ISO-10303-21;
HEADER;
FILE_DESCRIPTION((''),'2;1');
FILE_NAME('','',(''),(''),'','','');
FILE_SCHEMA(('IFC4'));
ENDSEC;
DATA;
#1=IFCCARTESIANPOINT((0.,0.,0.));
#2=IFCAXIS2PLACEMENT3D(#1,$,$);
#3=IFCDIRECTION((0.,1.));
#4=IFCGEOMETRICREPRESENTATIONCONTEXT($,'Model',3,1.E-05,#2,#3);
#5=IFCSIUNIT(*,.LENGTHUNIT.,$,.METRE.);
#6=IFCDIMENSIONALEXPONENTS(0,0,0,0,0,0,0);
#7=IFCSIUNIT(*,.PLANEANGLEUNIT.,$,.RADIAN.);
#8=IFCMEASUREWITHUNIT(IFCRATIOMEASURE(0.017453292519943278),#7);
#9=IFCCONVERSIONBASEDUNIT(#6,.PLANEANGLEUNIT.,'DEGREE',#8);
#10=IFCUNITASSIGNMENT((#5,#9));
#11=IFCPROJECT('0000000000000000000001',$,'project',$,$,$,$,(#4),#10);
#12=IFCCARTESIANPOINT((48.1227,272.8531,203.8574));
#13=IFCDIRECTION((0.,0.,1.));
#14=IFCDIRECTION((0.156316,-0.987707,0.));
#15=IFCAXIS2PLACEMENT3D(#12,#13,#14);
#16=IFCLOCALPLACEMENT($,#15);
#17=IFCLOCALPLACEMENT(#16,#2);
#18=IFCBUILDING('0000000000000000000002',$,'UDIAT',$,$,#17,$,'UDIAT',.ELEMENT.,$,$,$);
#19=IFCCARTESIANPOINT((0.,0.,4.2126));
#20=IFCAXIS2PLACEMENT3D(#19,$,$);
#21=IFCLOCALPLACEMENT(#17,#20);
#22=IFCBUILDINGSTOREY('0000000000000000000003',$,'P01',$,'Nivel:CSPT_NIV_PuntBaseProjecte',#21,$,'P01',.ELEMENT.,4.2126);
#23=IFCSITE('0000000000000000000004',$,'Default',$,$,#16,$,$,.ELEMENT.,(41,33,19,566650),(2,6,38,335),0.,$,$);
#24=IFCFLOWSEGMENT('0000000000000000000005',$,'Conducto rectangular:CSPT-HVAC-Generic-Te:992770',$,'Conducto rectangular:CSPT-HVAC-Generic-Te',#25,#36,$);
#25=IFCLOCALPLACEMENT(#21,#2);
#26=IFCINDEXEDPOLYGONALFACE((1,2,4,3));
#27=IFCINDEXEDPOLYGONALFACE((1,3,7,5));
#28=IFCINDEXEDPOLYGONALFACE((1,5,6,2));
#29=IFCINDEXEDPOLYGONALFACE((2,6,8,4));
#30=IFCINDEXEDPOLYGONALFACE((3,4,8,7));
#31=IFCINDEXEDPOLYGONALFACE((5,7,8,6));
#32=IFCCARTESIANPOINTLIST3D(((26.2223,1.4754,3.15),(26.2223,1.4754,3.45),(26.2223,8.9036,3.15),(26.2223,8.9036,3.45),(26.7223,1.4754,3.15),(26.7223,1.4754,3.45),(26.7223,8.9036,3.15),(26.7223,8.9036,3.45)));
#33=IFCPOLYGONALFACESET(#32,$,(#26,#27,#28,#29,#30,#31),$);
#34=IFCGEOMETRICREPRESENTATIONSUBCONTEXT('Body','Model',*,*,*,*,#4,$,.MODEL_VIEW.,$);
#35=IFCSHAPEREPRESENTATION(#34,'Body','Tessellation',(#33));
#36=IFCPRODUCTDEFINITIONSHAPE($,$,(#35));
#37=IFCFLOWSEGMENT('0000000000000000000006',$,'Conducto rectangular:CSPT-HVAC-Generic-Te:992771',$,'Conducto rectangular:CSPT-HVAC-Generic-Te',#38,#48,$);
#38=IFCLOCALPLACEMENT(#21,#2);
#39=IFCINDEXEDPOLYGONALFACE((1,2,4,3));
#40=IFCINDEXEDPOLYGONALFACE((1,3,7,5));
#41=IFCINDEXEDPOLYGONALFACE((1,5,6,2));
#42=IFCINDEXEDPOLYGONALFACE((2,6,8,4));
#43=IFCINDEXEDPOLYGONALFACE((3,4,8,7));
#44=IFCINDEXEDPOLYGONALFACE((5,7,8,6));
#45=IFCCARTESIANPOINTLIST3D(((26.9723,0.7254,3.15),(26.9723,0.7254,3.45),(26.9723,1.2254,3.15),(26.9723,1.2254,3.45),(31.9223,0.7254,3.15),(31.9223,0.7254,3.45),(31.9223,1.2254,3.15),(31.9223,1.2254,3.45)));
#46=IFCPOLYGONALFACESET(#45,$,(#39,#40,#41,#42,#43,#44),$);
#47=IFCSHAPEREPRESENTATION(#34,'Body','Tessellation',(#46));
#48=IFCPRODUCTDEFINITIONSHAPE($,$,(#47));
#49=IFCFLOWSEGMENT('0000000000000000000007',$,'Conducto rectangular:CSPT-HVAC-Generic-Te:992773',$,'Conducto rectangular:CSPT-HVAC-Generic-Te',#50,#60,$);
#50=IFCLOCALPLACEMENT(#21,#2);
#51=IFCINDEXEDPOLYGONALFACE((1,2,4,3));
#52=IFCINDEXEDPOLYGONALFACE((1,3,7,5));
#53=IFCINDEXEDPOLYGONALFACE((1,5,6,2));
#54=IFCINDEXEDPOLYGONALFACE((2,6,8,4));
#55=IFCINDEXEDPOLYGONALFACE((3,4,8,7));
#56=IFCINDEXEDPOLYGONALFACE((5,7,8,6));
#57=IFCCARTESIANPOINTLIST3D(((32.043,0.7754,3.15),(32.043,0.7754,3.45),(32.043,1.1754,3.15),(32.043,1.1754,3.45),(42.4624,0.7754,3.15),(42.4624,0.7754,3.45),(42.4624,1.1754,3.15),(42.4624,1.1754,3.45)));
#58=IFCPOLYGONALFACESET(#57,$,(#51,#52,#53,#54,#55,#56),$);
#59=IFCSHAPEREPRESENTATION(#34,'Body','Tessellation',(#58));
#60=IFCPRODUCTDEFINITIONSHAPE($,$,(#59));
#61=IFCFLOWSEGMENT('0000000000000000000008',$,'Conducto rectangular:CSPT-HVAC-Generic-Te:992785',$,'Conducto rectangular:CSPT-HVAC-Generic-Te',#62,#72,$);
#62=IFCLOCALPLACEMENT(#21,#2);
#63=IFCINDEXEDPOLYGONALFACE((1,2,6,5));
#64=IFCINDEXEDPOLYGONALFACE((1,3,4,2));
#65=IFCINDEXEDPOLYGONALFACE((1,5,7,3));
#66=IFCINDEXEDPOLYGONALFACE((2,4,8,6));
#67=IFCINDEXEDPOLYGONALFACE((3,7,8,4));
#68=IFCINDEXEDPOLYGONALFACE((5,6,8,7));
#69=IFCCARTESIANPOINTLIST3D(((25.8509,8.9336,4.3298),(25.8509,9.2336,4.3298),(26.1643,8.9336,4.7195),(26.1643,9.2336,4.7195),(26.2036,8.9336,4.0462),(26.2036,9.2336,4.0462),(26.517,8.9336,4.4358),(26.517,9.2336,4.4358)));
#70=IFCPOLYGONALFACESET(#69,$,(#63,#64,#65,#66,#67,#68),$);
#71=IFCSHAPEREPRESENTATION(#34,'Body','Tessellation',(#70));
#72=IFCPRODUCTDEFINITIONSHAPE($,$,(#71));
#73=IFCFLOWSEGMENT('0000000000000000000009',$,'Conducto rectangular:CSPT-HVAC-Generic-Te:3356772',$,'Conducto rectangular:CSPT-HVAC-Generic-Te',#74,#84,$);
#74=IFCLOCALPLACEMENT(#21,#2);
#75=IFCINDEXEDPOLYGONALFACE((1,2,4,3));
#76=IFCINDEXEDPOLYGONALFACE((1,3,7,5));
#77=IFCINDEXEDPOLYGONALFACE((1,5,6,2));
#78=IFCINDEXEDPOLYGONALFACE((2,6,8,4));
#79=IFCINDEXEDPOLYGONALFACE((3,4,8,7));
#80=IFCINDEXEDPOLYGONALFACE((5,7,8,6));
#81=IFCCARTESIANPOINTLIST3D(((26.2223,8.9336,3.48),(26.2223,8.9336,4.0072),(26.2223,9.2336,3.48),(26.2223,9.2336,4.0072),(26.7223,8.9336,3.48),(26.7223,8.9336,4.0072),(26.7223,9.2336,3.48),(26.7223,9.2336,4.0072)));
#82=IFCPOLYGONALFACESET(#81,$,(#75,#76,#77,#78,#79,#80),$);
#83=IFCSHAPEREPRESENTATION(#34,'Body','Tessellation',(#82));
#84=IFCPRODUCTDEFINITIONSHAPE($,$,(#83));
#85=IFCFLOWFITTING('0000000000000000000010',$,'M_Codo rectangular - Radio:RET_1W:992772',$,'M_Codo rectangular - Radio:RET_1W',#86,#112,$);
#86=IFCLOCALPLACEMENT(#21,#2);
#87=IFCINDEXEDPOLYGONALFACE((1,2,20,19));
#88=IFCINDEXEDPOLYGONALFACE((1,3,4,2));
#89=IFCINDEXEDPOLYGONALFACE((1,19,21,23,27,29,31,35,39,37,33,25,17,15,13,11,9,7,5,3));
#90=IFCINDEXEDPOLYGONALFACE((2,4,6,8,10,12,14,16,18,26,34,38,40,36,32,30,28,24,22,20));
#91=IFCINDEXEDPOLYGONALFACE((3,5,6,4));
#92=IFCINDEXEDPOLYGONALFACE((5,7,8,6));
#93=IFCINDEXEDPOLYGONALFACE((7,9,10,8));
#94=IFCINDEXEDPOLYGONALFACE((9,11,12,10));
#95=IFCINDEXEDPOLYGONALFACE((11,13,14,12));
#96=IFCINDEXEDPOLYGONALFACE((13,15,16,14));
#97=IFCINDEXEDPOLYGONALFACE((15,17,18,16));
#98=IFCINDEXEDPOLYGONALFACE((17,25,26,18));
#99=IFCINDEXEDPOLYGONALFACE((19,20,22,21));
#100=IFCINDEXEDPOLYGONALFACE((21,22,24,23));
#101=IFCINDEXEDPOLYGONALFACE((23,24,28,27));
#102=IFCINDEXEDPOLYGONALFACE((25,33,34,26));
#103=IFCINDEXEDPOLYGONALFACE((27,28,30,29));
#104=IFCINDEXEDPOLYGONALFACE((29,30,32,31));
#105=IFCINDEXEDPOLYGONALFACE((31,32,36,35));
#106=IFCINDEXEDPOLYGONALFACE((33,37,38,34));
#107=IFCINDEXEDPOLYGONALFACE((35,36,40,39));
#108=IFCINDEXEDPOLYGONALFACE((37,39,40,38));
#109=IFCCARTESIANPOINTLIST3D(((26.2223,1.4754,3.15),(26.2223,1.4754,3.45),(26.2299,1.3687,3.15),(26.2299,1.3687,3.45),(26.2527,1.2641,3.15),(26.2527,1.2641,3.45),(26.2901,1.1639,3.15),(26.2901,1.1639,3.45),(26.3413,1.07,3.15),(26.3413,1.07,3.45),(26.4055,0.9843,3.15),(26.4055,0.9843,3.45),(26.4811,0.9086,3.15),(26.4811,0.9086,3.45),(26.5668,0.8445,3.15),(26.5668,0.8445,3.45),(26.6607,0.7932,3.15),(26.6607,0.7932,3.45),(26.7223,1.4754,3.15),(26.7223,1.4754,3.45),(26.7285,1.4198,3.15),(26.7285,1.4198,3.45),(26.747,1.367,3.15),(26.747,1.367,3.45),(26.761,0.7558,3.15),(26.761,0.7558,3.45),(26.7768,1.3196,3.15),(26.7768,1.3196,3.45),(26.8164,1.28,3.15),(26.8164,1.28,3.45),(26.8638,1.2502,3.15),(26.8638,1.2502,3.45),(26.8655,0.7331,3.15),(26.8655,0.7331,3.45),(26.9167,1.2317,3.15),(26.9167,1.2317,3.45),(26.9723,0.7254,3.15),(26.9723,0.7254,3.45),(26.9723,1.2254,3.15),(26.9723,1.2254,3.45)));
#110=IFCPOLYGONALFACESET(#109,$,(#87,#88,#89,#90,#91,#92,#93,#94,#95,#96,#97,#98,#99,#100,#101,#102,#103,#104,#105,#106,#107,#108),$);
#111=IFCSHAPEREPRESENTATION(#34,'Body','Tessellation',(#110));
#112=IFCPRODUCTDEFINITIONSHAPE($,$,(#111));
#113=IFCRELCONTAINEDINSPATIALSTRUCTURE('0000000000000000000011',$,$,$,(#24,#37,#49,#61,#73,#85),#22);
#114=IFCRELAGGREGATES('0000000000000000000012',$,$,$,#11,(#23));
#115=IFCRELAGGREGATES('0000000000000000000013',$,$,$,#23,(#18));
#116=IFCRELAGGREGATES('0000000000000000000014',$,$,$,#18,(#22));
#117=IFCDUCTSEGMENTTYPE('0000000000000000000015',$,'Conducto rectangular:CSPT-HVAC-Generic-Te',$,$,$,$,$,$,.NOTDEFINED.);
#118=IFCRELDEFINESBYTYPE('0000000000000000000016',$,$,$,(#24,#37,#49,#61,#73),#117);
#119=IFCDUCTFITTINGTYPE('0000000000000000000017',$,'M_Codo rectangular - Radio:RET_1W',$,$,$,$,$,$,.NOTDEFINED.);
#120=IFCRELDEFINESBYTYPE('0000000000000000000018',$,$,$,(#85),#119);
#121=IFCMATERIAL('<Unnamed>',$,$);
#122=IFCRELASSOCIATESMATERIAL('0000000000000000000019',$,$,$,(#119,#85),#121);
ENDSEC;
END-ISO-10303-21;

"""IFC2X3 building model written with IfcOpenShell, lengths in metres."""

from ifc_helpers import new_model, entity, si_unit, converted_unit, direction, frame, frame_2d, origin, place, context, subcontext, project, spatial, polyline, circle_curve, parameter, trimmed, segment, composite_curve, rectangle, outline, extrude, source, transform, mapped, material, type_object, type_shapes, element, save


model = new_model("IFC2X3")

# Units and contexts
model_context = context("Model", 3, precision=1e-05, world=origin(), true_north=direction((0.0, 1.0)))
body_context = subcontext(model_context, "Body", "Model", "MODEL_VIEW")
ifc_project = project(units=[si_unit("LENGTHUNIT", "METRE"), converted_unit("PLANEANGLEUNIT", "DEGREE", entity("IfcRatioMeasure", 0.017453292519943278), si_unit("PLANEANGLEUNIT", "RADIAN"), dimensions=[0, 0, 0, 0, 0, 0, 0])], contexts=[model_context])

# Site, building, storey
site_placement = place(None, frame((48.1227, 272.8531, 203.8574), z_axis=(0.0, 0.0, 1.0), x_axis=(0.156316, -0.987707, 0.0)))
site = spatial("IfcSite", under=ifc_project, at=site_placement, Name="Default", CompositionType="ELEMENT", RefLatitude=(41, 33, 19, 566650), RefLongitude=(2, 6, 38, 335), RefElevation=0.0)
building_placement = place(site_placement, origin())
building = spatial("IfcBuilding", under=site, at=building_placement, Name="UDIAT", LongName="UDIAT", CompositionType="ELEMENT")
storey_placement = place(building_placement, frame((0.0, 0.0, 4.2126)))
storey = spatial("IfcBuildingStorey", under=building, at=storey_placement, Name="P01", ObjectType="Nivel:CSPT_NIV_PuntBaseProjecte", LongName="P01", CompositionType="ELEMENT", Elevation=4.2126)

# Flow segments
duct_segment_type = type_object("IfcDuctSegmentType", Name="Conducto rectangular:CSPT-HVAC-Generic-Te", PredefinedType="NOTDEFINED")
flow_segment_1_placement = place(storey_placement, origin())
element("IfcFlowSegment", 1, at=flow_segment_1_placement, inside=storey, type_object=duct_segment_type, Name="Conducto rectangular:CSPT-HVAC-Generic-Te:992770", ObjectType="Conducto rectangular:CSPT-HVAC-Generic-Te", context=body_context, shape_type="SweptSolid", body=[
    extrude(rectangle(XDim=7.4282, YDim=0.5, at=frame_2d((0.0, 0.0), x_axis=(1.0, 0.0))), frame((26.4723, 5.1895, 3.15), z_axis=(0.0, 0.0, 1.0), x_axis=(0.0, 1.0, 0.0)), (0.0, 0.0, 1.0), 0.3),
])
flow_segment_2_placement = place(storey_placement, origin())
element("IfcFlowSegment", 2, at=flow_segment_2_placement, inside=storey, type_object=duct_segment_type, Name="Conducto rectangular:CSPT-HVAC-Generic-Te:992771", ObjectType="Conducto rectangular:CSPT-HVAC-Generic-Te", context=body_context, shape_type="SweptSolid", body=[
    extrude(rectangle(XDim=4.95, YDim=0.5, at=frame_2d((0.0, 0.0), x_axis=(1.0, 0.0))), frame((29.4473, 0.9754, 3.15)), (0.0, 0.0, 1.0), 0.3),
])
flow_segment_3_placement = place(storey_placement, origin())
element("IfcFlowSegment", 3, at=flow_segment_3_placement, inside=storey, type_object=duct_segment_type, Name="Conducto rectangular:CSPT-HVAC-Generic-Te:992773", ObjectType="Conducto rectangular:CSPT-HVAC-Generic-Te", context=body_context, shape_type="SweptSolid", body=[
    extrude(rectangle(XDim=10.4195, YDim=0.4, at=frame_2d((0.0, 0.0), x_axis=(1.0, 0.0))), frame((37.2527, 0.9754, 3.15)), (0.0, 0.0, 1.0), 0.3),
])
flow_segment_4_placement = place(storey_placement, origin())
element("IfcFlowSegment", 4, at=flow_segment_4_placement, inside=storey, type_object=duct_segment_type, Name="Conducto rectangular:CSPT-HVAC-Generic-Te:992785", ObjectType="Conducto rectangular:CSPT-HVAC-Generic-Te", context=body_context, shape_type="SweptSolid", body=[
    extrude(rectangle(XDim=0.4526, YDim=0.3, at=frame_2d((0.0, 0.0), x_axis=(1.0, 0.0))), frame((26.0273, 9.0836, 4.188), z_axis=(0.626743, 0.0, 0.779226), x_axis=(0.779226, 0.0, -0.626743)), (0.0, 0.0, 1.0), 0.5),
])
flow_segment_5_placement = place(storey_placement, origin())
element("IfcFlowSegment", 5, at=flow_segment_5_placement, inside=storey, type_object=duct_segment_type, Name="Conducto rectangular:CSPT-HVAC-Generic-Te:3356772", ObjectType="Conducto rectangular:CSPT-HVAC-Generic-Te", context=body_context, shape_type="SweptSolid", body=[
    extrude(rectangle(XDim=0.3, YDim=0.5, at=frame_2d((0.0, 0.0), x_axis=(1.0, 0.0))), frame((26.4723, 9.0836, 3.48), z_axis=(0.0, 0.0, 1.0), x_axis=(0.0, -1.0, 0.0)), (0.0, 0.0, 1.0), 0.5272),
])

# Flow fitting
ifc_material_1 = material(Name="<Unnamed>")
duct_fitting_type_1 = type_object("IfcDuctFittingType", Name="M_Codo rectangular - Radio:RET_1W", PredefinedType="NOTDEFINED", material=ifc_material_1)
shared_shape_1 = source(origin(), body_context, "Body", "SweptSolid", [
    extrude(outline(composite_curve([segment(polyline([(-0.5, -0.25), (0.0, -0.25)]), True, "CONTINUOUS"), segment(trimmed(circle_curve(frame_2d((0.25, -0.25), x_axis=(0.0, 1.0)), 0.25), [parameter(0.0)], [parameter(90.0)], True, "PARAMETER"), False, "CONTINUOUS"), segment(polyline([(0.25, 0.0), (0.25, 0.5)]), True, "CONTINUOUS"), segment(trimmed(circle_curve(frame_2d((0.25, -0.25), x_axis=(0.0, 1.0)), 0.75), [parameter(0.0)], [parameter(90.0)], True, "PARAMETER"), True, "CONTINUOUS")], self_intersect=False)), frame((-0.25, 0.25, -0.15), z_axis=(0.0, 0.0, 1.0), x_axis=(-1.0, 0.0, 0.0)), (0.0, 0.0, 1.0), 0.3),
])
type_shapes(duct_fitting_type_1, [shared_shape_1])
flow_fitting_1_placement = place(storey_placement, frame((26.4723, 0.9754, 3.3), z_axis=(0.0, 0.0, 1.0), x_axis=(0.0, -1.0, 0.0)))
element("IfcFlowFitting", 6, at=flow_fitting_1_placement, inside=storey, type_object=duct_fitting_type_1, material=ifc_material_1, Name="M_Codo rectangular - Radio:RET_1W:992772", ObjectType="M_Codo rectangular - Radio:RET_1W", context=body_context, shape_type="MappedRepresentation", body=[
    mapped(shared_shape_1, transform((0.0, 0.0, 0.0), scale=1.0)),
])

save(model, "model.ifc")
